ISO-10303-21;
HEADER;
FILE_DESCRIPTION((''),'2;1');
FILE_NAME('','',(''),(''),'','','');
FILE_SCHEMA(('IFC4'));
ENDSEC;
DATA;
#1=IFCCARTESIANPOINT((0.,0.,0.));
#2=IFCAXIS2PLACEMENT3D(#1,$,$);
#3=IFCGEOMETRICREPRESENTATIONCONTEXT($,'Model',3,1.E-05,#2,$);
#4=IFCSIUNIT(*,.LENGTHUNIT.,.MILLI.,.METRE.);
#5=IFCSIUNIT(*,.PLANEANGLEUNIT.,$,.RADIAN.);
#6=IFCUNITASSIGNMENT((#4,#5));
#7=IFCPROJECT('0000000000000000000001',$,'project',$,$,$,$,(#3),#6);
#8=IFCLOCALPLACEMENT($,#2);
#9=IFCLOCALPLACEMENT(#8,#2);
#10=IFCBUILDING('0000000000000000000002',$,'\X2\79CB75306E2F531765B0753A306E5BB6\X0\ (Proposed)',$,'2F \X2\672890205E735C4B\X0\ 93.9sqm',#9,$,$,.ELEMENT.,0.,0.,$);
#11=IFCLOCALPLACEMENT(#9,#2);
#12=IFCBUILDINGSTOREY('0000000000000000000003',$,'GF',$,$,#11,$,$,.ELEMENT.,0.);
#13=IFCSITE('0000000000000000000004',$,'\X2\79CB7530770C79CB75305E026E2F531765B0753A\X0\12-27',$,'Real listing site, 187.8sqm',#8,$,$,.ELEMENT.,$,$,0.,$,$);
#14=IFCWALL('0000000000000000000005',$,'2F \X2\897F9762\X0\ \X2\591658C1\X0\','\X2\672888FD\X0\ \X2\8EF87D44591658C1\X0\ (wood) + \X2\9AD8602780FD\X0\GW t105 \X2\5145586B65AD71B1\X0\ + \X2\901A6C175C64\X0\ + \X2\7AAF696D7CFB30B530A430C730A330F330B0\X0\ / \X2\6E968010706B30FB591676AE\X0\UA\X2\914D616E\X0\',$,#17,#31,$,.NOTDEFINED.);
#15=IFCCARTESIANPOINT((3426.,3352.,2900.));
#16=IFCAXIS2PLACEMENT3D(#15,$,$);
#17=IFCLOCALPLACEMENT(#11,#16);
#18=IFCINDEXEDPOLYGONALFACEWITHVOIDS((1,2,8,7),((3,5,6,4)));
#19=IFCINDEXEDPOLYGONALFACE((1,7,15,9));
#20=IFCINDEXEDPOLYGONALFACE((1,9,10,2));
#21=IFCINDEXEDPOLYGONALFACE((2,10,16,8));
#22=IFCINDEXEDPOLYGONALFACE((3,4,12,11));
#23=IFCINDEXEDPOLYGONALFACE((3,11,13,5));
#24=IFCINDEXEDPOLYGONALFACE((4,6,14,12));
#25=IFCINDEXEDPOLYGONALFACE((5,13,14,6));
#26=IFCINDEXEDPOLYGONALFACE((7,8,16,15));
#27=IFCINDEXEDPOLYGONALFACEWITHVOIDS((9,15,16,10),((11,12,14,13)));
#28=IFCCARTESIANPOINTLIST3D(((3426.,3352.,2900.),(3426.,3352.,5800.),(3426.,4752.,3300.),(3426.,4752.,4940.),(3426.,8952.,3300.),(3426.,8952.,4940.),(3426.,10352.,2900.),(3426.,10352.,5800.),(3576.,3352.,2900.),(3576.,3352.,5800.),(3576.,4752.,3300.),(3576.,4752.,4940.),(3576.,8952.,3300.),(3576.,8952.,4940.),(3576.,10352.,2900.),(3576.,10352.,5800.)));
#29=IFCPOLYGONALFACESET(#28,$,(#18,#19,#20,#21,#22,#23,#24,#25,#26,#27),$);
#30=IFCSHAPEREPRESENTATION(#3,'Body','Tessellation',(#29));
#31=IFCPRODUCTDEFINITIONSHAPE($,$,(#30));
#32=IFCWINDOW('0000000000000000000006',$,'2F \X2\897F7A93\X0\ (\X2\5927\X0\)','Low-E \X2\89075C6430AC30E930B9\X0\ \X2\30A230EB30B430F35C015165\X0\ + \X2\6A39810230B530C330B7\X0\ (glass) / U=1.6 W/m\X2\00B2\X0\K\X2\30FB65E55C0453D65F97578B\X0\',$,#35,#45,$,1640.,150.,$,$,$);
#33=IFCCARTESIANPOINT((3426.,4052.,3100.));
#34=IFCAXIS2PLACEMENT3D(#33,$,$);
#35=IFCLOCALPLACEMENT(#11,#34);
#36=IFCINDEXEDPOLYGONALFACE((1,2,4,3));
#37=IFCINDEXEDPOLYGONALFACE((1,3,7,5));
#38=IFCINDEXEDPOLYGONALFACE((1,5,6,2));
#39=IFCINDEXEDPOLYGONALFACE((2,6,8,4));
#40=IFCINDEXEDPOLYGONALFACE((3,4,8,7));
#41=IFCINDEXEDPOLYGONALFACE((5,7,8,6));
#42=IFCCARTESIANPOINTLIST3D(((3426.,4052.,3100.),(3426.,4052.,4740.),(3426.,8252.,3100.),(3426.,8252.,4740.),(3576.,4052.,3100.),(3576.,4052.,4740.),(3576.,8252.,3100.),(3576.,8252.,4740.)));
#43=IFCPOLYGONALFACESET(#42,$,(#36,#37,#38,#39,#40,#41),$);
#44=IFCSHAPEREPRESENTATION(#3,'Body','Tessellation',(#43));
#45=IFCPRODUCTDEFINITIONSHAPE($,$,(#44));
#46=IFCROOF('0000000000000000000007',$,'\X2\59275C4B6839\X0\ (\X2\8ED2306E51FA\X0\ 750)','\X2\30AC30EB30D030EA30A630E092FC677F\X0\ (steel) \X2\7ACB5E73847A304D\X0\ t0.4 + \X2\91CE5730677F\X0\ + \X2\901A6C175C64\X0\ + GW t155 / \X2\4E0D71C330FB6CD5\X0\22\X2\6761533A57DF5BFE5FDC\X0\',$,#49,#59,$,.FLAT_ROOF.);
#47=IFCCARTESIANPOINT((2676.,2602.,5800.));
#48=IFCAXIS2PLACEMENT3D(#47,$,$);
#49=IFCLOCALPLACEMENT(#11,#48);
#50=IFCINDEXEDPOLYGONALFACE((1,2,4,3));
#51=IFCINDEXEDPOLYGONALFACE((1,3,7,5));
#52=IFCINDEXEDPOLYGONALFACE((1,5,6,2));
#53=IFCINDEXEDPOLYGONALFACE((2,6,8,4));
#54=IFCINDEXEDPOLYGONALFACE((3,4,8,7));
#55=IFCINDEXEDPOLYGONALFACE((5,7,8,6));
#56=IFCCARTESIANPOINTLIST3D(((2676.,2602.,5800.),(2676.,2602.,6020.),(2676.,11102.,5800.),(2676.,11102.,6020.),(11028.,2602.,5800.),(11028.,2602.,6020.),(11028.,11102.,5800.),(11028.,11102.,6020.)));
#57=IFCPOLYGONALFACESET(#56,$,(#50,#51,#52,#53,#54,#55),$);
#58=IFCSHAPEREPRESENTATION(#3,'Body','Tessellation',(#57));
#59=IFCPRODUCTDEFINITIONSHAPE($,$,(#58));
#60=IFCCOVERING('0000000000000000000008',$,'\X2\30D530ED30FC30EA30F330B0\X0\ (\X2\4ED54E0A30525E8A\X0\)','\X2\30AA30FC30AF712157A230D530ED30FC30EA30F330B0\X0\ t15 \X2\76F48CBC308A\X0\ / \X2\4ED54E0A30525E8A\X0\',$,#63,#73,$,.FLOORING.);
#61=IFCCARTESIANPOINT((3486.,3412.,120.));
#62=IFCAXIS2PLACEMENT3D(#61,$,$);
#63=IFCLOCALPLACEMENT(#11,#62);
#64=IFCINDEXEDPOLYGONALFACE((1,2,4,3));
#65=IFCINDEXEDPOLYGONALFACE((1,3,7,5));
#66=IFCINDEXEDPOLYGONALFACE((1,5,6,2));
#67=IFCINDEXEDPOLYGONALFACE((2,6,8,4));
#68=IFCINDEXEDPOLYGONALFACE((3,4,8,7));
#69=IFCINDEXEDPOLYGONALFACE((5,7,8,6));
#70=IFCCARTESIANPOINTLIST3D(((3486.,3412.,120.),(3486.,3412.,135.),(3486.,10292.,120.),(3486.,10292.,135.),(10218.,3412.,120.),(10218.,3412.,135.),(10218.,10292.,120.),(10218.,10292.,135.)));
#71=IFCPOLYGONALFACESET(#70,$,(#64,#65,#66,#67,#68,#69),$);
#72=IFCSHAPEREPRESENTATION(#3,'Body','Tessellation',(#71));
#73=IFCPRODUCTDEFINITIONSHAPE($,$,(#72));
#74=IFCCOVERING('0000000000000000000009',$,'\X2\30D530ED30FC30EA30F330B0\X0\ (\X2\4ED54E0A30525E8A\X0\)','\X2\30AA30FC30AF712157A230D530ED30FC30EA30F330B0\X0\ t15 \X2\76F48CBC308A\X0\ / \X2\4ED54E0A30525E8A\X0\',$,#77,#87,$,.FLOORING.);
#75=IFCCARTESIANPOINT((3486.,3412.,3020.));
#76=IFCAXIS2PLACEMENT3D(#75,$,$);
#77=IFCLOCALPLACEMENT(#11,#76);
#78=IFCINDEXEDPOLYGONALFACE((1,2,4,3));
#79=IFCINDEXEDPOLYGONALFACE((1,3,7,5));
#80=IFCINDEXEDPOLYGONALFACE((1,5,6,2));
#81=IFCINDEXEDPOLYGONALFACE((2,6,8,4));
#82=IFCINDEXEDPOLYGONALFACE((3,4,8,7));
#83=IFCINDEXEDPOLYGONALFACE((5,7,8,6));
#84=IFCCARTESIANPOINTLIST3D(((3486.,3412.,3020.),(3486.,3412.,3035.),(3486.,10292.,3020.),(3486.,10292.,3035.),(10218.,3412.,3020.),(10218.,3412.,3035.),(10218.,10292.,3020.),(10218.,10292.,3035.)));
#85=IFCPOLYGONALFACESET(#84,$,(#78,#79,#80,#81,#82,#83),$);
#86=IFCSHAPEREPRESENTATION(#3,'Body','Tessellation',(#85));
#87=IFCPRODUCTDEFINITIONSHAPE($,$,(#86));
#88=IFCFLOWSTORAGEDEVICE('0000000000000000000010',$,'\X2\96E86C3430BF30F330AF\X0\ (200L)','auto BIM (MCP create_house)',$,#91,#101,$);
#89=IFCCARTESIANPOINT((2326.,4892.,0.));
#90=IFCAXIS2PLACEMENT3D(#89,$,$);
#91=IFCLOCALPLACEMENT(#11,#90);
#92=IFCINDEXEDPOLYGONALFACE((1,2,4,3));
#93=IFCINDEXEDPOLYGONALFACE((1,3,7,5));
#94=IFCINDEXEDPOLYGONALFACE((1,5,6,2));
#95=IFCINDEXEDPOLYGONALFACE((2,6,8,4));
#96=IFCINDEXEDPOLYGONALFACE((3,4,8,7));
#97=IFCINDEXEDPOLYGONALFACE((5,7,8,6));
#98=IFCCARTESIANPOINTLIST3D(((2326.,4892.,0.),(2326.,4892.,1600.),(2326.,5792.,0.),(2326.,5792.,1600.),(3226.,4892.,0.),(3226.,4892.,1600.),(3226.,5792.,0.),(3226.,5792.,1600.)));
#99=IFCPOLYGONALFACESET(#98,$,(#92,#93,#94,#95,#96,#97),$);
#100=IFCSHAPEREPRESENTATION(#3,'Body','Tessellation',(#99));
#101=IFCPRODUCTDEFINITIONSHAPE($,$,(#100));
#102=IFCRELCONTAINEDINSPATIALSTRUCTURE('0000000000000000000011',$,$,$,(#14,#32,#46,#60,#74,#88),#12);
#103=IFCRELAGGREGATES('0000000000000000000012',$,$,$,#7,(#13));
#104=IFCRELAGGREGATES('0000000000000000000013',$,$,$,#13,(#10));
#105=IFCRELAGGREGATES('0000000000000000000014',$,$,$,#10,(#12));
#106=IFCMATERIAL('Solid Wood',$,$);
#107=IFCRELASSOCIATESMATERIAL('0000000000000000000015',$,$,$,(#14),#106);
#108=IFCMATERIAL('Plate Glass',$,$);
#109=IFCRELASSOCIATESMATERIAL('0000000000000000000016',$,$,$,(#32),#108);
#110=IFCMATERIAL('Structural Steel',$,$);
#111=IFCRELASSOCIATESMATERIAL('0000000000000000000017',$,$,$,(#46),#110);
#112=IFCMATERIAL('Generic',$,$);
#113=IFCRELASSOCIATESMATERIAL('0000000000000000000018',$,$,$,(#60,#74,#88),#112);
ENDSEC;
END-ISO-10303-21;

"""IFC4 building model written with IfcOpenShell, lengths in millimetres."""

from ifc_helpers import new_model, si_unit, frame, frame_2d, origin, place, context, project, spatial, rectangle, extrude, material, element, fill, save


model = new_model("IFC4")

# Units and contexts
model_context = context("Model", 3, precision=1e-05, world=origin())
ifc_project = project(units=[si_unit("LENGTHUNIT", "METRE", prefix="MILLI"), si_unit("PLANEANGLEUNIT", "RADIAN")], contexts=[model_context])

# Site, building, storey
site_placement = place(None, origin())
site = spatial("IfcSite", under=ifc_project, at=site_placement, Name="秋田県秋田市港北新町12-27", ObjectType="Real listing site, 187.8sqm", CompositionType="ELEMENT", RefElevation=0.0)
building_placement = place(site_placement, origin())
building = spatial("IfcBuilding", under=site, at=building_placement, Name="秋田港北新町の家 (Proposed)", ObjectType="2F 木造平屋 93.9sqm", CompositionType="ELEMENT", ElevationOfRefHeight=0.0, ElevationOfTerrain=0.0)
storey_placement = place(building_placement, origin())
storey = spatial("IfcBuildingStorey", under=building, at=storey_placement, Name="GF", CompositionType="ELEMENT", Elevation=0.0)

# Shared definitions
ifc_material_1 = material(Name="Solid Wood")

# Shared definitions
ifc_material_2 = material(Name="Plate Glass")

# Wall, opening, window
wall_1_placement = place(storey_placement, frame((3426.0, 3352.0, 2900.0)))
wall_1 = element("IfcWall", 1, at=wall_1_placement, inside=storey, material=ifc_material_1, Name="2F 西面 外壁", Description="木製 軸組外壁 (wood) + 高性能GW t105 充填断熱 + 通気層 + 窯業系サイディング / 準耐火・外皮UA配慮", PredefinedType="NOTDEFINED", context=model_context, shape_type="SweptSolid", body=[
    extrude(rectangle(XDim=150.0, YDim=7000.0, at=frame_2d((75.0, 3500.0))), frame((3426.0, 3352.0, 2900.0)), (0.0, 0.0, 1.0), 2900.0),
])
opening_1_placement = place(storey_placement, frame((3426.0, 4052.0, 3100.0)))
opening_1 = element("IfcOpeningElement", 2, at=opening_1_placement, cuts=wall_1, PredefinedType="NOTDEFINED", context=model_context, shape_type="SweptSolid", body=[
    extrude(rectangle(XDim=150.0, YDim=4200.0, at=frame_2d((75.0, 2100.0))), frame((3426.0, 4052.0, 3100.0)), (0.0, 0.0, 1.0), 1640.0),
])
window_1_placement = place(storey_placement, frame((3426.0, 4052.0, 3100.0)))
window_1 = element("IfcWindow", 3, at=window_1_placement, inside=storey, material=ifc_material_2, Name="2F 西窓 (大)", Description="Low-E 複層ガラス アルゴン封入 + 樹脂サッシ (glass) / U=1.6 W/m²K・日射取得型", OverallHeight=1640.0, OverallWidth=150.0, context=model_context, shape_type="SweptSolid", body=[
    extrude(rectangle(XDim=150.0, YDim=4200.0, at=frame_2d((75.0, 2100.0))), frame((3426.0, 4052.0, 3100.0)), (0.0, 0.0, 1.0), 1640.0),
])
fill(opening_1, window_1)

# Roof
ifc_material_3 = material(Name="Structural Steel")
roof_placement = place(storey_placement, frame((2676.0, 2602.0, 5800.0)))
element("IfcRoof", 4, at=roof_placement, inside=storey, material=ifc_material_3, Name="大屋根 (軒の出 750)", Description="ガルバリウム鋼板 (steel) 立平葺き t0.4 + 野地板 + 通気層 + GW t155 / 不燃・法22条区域対応", PredefinedType="FLAT_ROOF", context=model_context, shape_type="SweptSolid", body=[
    extrude(rectangle(XDim=8352.0, YDim=8500.0, at=frame_2d((4176.0, 4250.0))), frame((2676.0, 2602.0, 5800.0)), (0.0, 0.0, 1.0), 220.0),
])

# Coverings
ifc_material_4 = material(Name="Generic")
covering_1_placement = place(storey_placement, frame((3486.0, 3412.0, 120.0)))
element("IfcCovering", 5, at=covering_1_placement, inside=storey, material=ifc_material_4, Name="フローリング (仕上げ床)", Description="オーク無垢フローリング t15 直貼り / 仕上げ床", PredefinedType="FLOORING", context=model_context, shape_type="SweptSolid", body=[
    extrude(rectangle(XDim=6732.0, YDim=6880.0, at=frame_2d((3366.0, 3440.0))), frame((3486.0, 3412.0, 120.0)), (0.0, 0.0, 1.0), 15.0),
])
covering_2_placement = place(storey_placement, frame((3486.0, 3412.0, 3020.0)))
element("IfcCovering", 6, at=covering_2_placement, inside=storey, material=ifc_material_4, Name="フローリング (仕上げ床)", Description="オーク無垢フローリング t15 直貼り / 仕上げ床", PredefinedType="FLOORING", context=model_context, shape_type="SweptSolid", body=[
    extrude(rectangle(XDim=6732.0, YDim=6880.0, at=frame_2d((3366.0, 3440.0))), frame((3486.0, 3412.0, 3020.0)), (0.0, 0.0, 1.0), 15.0),
])

# Flow storage device
flow_storage_device_placement = place(storey_placement, frame((2326.0, 4892.0, 0.0)))
element("IfcFlowStorageDevice", 7, at=flow_storage_device_placement, inside=storey, material=ifc_material_4, Name="雨水タンク (200L)", Description="auto BIM (MCP create_house)", context=model_context, shape_type="SweptSolid", body=[
    extrude(rectangle(XDim=900.0, YDim=900.0, at=frame_2d((450.0, 450.0))), frame((2326.0, 4892.0, 0.0)), (0.0, 0.0, 1.0), 1600.0),
])

save(model, "model.ifc")
